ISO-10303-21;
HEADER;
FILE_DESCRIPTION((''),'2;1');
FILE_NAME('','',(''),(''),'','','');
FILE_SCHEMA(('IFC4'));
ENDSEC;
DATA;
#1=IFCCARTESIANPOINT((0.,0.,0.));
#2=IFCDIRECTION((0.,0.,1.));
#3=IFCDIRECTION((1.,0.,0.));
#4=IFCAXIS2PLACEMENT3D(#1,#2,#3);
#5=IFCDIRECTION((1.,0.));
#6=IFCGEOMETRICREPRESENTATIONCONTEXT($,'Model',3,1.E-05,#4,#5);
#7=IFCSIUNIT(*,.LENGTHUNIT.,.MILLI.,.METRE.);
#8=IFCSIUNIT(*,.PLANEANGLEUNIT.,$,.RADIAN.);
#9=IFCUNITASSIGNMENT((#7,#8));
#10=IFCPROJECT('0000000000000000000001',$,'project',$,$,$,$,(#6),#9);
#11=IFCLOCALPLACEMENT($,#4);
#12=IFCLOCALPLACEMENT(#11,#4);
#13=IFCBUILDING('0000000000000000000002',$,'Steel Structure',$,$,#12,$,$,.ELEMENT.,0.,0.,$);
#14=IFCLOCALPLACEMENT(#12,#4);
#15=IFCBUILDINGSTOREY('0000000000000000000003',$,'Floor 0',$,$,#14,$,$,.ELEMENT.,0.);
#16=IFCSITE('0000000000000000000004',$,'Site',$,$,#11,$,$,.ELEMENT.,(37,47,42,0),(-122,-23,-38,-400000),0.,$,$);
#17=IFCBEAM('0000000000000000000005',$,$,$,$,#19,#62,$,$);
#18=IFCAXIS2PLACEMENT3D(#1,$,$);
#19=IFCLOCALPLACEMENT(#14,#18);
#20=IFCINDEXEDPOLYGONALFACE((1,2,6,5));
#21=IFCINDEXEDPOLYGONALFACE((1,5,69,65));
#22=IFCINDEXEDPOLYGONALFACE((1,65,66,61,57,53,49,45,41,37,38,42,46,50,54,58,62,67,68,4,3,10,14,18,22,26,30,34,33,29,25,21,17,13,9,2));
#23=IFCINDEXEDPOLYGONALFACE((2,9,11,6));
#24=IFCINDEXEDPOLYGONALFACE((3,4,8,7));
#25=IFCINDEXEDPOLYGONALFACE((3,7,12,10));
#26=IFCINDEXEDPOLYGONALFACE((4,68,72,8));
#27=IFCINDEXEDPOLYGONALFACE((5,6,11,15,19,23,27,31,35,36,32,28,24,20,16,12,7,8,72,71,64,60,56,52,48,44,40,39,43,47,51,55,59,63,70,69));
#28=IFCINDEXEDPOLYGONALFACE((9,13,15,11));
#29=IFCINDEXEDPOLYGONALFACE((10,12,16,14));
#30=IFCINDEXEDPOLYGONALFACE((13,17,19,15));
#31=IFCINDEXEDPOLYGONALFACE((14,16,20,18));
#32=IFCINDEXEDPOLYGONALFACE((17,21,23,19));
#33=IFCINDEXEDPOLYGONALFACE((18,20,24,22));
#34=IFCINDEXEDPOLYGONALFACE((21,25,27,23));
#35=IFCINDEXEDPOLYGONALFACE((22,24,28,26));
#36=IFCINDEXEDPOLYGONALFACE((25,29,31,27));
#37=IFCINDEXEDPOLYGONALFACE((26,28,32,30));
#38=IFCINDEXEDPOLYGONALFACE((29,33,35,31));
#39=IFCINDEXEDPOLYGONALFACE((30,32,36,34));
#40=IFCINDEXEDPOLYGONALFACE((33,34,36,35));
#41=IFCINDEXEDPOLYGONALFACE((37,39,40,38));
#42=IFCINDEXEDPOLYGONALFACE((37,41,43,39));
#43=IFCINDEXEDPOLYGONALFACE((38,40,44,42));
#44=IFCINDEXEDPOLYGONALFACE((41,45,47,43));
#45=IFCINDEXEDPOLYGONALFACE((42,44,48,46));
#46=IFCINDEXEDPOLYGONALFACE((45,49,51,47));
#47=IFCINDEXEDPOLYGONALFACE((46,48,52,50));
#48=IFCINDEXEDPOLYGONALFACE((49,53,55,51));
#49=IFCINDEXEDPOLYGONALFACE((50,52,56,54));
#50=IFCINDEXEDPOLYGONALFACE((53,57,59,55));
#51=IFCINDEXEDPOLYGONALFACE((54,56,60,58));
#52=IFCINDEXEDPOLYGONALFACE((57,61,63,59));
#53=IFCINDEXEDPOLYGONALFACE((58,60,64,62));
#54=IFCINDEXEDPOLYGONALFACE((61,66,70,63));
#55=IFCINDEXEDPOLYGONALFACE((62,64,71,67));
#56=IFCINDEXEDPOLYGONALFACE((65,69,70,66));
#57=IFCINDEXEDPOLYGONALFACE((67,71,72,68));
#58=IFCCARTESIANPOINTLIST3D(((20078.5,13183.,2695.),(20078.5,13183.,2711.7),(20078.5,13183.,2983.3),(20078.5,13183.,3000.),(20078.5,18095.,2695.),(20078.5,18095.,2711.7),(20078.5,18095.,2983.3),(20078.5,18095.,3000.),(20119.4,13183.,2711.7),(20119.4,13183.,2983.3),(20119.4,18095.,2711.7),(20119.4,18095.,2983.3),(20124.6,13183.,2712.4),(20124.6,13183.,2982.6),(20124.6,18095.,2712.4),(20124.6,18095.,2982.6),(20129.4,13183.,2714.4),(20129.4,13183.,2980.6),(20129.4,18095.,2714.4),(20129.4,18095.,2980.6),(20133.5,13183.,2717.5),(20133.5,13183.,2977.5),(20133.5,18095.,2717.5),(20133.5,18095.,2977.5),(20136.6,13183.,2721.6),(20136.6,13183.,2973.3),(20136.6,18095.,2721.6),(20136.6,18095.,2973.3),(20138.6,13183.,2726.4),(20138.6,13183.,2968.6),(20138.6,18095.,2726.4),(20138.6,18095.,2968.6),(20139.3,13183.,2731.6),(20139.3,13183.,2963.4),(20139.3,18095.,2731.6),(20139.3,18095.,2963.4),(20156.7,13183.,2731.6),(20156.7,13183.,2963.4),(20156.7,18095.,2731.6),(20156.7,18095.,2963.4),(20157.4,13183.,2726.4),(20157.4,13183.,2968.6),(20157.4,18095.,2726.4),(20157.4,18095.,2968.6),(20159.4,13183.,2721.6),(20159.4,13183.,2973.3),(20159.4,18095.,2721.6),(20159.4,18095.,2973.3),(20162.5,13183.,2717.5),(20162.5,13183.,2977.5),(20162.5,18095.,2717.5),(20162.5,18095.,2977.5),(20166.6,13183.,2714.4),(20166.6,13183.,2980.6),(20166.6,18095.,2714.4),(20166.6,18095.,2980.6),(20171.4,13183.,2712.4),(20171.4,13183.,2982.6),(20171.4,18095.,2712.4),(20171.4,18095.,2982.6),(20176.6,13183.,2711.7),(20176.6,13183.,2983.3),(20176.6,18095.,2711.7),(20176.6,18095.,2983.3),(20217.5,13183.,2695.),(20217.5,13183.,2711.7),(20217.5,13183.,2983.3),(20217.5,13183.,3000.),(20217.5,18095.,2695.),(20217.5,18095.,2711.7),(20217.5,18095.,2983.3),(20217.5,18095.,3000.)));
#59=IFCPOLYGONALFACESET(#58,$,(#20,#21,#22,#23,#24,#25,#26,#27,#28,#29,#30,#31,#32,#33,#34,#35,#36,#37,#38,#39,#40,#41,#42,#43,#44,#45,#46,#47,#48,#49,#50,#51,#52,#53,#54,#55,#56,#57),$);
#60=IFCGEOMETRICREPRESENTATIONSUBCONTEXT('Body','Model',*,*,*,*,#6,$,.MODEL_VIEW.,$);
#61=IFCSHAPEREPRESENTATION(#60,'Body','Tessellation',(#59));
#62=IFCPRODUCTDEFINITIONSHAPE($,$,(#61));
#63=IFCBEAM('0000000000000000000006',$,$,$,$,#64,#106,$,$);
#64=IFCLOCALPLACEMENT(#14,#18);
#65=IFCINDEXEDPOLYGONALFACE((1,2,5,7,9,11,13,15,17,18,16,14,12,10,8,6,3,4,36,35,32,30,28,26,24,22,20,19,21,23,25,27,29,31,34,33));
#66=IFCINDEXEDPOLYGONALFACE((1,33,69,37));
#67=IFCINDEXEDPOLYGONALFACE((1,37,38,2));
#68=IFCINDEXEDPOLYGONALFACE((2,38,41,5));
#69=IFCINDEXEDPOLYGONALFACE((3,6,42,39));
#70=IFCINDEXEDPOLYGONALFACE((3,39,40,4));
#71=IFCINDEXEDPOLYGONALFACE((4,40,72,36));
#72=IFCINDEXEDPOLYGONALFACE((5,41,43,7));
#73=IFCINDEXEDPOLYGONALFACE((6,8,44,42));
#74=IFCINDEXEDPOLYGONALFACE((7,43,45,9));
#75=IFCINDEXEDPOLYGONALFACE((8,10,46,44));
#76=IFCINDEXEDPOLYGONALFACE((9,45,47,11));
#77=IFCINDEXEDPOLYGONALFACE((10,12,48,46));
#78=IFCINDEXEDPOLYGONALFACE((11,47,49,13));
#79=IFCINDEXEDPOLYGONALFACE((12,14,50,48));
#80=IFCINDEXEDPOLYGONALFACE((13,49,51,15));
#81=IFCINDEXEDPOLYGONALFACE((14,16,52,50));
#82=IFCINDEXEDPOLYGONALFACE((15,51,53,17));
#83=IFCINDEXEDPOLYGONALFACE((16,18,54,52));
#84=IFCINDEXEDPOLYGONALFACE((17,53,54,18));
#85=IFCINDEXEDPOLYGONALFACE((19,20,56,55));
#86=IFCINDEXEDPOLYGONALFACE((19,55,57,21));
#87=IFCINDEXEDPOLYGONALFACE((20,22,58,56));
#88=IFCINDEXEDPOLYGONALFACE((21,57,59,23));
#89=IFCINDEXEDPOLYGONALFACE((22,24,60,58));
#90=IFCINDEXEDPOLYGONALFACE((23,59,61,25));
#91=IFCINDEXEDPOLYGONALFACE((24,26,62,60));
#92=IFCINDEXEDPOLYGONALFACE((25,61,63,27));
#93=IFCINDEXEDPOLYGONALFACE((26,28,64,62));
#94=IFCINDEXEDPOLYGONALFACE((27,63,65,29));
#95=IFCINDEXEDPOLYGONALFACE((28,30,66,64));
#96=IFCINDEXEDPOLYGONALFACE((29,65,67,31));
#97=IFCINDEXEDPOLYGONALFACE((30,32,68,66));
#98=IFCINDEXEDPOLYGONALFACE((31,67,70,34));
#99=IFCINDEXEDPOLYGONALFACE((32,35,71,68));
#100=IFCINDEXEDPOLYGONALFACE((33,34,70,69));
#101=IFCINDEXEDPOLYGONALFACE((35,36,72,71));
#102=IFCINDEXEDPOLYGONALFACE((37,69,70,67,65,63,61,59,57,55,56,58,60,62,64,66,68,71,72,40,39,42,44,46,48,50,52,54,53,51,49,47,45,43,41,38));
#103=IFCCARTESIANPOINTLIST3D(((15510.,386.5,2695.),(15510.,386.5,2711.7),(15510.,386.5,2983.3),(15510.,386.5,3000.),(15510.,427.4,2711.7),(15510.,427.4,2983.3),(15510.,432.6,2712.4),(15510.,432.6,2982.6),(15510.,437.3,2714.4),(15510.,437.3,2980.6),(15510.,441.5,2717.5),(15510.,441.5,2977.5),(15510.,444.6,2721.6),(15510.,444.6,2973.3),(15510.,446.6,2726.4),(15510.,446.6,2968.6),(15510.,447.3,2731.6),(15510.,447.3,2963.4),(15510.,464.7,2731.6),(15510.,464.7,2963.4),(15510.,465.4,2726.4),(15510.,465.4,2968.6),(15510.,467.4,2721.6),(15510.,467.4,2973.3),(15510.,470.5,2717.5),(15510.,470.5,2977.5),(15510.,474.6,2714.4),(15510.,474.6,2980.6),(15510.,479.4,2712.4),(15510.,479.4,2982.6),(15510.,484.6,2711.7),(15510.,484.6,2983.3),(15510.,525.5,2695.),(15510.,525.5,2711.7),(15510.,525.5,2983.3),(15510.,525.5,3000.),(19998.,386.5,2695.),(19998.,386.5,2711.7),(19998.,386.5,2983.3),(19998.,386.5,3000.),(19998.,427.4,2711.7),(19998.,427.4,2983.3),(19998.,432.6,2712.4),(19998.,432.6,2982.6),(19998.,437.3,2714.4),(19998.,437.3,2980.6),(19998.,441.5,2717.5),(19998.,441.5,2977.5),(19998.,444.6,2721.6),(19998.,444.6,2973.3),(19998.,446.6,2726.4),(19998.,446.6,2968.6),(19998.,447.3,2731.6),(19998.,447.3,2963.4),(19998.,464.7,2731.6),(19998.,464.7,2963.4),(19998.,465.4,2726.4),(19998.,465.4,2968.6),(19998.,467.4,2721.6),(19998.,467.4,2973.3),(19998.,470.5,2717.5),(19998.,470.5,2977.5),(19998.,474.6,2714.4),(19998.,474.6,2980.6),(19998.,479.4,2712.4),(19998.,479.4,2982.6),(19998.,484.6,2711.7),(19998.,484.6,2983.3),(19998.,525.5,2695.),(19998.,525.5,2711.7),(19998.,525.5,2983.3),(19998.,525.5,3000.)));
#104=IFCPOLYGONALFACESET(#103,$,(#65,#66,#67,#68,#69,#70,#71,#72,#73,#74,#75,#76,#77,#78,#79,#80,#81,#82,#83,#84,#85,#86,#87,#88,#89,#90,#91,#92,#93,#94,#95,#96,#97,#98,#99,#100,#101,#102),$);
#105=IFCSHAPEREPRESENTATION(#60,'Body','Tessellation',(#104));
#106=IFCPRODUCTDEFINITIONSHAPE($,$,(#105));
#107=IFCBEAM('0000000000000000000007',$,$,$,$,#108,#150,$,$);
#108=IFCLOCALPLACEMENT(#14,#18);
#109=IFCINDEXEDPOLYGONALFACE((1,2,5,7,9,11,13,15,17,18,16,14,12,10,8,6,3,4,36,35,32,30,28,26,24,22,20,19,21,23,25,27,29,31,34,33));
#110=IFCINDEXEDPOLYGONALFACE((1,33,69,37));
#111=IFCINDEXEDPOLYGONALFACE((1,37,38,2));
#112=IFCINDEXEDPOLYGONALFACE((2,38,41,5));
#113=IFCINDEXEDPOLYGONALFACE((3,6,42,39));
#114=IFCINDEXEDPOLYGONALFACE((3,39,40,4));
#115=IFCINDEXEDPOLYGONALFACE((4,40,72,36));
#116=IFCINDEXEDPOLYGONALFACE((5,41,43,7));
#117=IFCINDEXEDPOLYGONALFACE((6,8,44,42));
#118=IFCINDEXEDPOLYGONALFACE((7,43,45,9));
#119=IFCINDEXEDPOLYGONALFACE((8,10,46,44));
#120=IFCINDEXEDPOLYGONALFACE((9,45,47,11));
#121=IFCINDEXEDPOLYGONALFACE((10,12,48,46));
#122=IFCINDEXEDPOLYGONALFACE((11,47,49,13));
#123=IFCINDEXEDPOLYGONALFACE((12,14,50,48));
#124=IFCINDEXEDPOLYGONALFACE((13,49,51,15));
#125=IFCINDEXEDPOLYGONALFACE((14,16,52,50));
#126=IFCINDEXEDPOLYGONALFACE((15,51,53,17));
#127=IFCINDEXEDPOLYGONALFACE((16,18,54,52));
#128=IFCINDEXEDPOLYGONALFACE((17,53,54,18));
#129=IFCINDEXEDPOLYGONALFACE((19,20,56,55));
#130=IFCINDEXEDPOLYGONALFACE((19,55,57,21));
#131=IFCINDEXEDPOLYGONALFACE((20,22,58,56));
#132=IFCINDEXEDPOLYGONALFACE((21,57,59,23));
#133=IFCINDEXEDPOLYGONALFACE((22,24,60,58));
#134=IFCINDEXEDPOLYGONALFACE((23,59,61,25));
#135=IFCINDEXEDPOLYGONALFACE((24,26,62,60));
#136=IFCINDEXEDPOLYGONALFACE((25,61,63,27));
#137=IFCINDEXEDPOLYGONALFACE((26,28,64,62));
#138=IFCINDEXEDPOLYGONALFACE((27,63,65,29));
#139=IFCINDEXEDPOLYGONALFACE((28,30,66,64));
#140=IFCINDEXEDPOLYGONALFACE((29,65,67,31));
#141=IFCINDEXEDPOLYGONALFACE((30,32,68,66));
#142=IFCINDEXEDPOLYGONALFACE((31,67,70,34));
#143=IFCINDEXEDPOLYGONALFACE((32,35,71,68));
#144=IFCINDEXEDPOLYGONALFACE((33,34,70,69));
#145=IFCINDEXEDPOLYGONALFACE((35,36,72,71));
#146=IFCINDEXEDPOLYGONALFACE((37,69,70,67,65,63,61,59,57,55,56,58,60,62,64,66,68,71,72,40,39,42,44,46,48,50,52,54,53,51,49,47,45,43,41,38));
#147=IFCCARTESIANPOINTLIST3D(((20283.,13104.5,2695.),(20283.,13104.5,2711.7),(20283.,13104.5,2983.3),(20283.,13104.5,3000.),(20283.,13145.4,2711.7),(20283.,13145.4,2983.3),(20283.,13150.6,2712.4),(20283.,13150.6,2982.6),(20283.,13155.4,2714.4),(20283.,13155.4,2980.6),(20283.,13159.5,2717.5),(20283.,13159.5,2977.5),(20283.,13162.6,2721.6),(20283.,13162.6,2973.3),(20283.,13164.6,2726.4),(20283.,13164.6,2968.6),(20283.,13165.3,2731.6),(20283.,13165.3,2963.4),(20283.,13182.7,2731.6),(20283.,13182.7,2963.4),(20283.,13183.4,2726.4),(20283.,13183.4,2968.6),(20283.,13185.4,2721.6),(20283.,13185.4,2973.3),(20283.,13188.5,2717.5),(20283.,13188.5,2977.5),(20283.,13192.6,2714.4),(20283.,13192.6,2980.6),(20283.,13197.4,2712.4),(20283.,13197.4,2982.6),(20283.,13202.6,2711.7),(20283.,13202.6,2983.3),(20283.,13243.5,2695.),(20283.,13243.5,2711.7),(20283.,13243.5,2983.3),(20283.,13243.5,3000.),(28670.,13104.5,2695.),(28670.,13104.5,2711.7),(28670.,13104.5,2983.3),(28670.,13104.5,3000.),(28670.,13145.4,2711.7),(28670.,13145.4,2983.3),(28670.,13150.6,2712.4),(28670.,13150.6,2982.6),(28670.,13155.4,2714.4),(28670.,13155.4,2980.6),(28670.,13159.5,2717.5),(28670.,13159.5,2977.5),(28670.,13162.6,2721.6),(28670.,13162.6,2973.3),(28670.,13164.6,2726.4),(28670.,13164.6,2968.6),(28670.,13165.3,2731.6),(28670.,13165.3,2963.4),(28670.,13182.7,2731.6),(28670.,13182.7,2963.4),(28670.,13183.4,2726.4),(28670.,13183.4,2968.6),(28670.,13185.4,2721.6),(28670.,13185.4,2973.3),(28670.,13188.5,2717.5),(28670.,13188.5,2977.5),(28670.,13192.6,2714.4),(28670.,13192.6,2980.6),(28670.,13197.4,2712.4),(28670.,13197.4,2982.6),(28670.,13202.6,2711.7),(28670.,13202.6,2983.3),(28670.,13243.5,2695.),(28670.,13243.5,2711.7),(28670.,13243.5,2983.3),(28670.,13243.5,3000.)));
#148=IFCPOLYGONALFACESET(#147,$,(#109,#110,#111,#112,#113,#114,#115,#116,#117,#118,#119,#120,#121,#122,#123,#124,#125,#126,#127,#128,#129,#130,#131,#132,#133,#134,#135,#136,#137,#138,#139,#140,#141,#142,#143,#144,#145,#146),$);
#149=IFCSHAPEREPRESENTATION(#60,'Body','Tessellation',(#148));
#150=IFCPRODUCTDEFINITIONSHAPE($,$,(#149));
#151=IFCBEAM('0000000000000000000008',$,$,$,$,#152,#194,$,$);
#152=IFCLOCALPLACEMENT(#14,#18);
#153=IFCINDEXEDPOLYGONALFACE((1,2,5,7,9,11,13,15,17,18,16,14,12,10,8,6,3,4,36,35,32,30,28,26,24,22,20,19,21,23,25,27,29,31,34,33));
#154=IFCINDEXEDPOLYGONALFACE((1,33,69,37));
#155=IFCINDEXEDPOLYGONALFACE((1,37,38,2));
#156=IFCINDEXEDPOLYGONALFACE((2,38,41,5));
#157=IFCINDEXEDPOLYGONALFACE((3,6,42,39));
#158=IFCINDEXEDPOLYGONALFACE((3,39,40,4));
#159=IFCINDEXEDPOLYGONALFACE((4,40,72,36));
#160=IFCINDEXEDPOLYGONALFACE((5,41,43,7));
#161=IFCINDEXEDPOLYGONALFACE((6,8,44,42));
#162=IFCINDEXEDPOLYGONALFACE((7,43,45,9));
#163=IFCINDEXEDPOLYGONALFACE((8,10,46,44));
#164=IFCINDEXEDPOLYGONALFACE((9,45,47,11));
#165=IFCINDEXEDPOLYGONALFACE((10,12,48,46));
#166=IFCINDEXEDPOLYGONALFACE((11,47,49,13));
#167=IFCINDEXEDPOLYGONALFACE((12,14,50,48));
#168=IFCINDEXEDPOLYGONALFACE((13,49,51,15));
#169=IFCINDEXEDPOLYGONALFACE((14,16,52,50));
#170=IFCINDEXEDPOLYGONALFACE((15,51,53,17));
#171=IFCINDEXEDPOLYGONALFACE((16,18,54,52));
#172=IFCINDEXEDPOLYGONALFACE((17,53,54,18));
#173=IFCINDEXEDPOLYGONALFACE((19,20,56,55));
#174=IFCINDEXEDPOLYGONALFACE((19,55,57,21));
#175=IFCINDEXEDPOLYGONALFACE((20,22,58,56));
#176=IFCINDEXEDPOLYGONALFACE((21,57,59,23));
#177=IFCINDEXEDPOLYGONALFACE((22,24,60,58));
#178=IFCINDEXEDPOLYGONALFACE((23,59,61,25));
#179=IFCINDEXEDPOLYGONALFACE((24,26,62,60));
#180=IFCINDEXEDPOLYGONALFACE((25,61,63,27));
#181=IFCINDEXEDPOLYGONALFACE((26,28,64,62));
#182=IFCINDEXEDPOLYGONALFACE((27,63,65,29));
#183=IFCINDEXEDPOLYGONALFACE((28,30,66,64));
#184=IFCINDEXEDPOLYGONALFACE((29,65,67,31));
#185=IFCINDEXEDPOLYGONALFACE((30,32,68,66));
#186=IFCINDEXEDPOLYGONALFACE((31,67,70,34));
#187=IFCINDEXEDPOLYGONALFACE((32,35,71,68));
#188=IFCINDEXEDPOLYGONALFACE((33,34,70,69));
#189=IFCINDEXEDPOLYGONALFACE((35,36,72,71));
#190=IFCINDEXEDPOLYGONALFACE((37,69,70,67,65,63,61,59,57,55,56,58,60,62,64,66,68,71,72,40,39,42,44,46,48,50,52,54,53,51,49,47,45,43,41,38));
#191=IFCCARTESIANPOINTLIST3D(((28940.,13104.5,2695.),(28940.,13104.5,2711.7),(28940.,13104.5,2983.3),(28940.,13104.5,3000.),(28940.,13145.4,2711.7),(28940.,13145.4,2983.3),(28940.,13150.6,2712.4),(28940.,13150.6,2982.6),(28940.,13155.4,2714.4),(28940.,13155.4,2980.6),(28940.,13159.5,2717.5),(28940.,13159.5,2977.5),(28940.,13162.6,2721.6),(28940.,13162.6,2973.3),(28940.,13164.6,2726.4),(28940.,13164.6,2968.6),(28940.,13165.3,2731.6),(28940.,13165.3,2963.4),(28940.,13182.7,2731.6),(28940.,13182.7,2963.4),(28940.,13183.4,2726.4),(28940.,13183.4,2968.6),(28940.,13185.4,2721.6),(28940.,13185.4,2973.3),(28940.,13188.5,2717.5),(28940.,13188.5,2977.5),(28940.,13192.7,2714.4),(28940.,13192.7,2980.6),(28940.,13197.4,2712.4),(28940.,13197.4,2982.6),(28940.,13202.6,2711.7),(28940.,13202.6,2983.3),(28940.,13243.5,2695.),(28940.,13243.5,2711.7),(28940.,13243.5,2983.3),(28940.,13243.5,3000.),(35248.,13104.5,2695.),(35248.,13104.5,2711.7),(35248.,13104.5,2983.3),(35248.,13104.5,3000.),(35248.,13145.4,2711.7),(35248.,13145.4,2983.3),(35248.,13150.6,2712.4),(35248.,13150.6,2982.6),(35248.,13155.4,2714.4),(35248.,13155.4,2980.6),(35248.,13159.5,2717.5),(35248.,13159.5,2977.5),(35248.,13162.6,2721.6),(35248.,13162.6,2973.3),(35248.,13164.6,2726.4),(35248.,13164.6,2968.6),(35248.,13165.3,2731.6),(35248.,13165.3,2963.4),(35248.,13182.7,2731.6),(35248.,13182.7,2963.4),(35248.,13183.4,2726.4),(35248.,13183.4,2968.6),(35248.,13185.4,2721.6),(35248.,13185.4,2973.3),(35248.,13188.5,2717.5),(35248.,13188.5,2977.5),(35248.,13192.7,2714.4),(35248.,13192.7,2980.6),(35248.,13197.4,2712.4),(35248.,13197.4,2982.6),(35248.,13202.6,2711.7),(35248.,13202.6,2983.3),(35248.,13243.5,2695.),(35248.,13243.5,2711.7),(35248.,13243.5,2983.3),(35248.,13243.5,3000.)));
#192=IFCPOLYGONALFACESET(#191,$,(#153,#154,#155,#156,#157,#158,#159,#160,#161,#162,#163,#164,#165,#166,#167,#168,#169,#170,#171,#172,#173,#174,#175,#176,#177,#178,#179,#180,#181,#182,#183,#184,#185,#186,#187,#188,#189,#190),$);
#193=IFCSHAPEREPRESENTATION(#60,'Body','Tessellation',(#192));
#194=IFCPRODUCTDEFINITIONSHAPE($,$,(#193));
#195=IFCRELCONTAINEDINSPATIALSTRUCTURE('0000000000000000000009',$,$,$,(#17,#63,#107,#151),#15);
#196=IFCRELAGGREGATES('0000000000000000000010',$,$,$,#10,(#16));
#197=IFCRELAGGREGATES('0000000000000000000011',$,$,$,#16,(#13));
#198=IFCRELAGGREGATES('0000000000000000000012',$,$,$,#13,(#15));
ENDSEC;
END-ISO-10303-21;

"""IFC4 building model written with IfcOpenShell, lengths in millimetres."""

from ifc_helpers import new_model, si_unit, direction, frame, origin_with_axes, origin_2d_with_axis, place, context, subcontext, project, spatial, i_section, extrude, element, save


model = new_model("IFC4")

# Units and contexts
model_context = context("Model", 3, precision=1e-05, world=origin_with_axes(), true_north=direction((1.0, 0.0)))
body_context = subcontext(model_context, "Body", "Model", "MODEL_VIEW")
ifc_project = project(units=[si_unit("LENGTHUNIT", "METRE", prefix="MILLI"), si_unit("PLANEANGLEUNIT", "RADIAN")], contexts=[model_context])

# Site, building, storey
site_placement = place(None, origin_with_axes())
site = spatial("IfcSite", under=ifc_project, at=site_placement, Name="Site", CompositionType="ELEMENT", RefLatitude=(37, 47, 42, 0), RefLongitude=(-122, -23, -38, -400000), RefElevation=0.0)
building_placement = place(site_placement, origin_with_axes())
building = spatial("IfcBuilding", under=site, at=building_placement, Name="Steel Structure", CompositionType="ELEMENT", ElevationOfRefHeight=0.0, ElevationOfTerrain=0.0)
storey_placement = place(building_placement, origin_with_axes())
storey = spatial("IfcBuildingStorey", under=building, at=storey_placement, Name="Floor 0", CompositionType="ELEMENT", Elevation=0.0)

# Beams
for number, where, z_axis, x_axis in (
    (1, (20148.0, 13183.0, 2695.0), (0.0, 1.0, 0.0), (-1.0, 0.0, 0.0)),
):
    element("IfcBeam", number, at=place(storey_placement, frame(where, z_axis=z_axis, x_axis=x_axis)), inside=storey, context=body_context, shape_type="SweptSolid", body=[
        extrude(i_section(OverallWidth=139.0, OverallDepth=305.0, WebThickness=17.4, FlangeThickness=16.7, FilletRadius=19.9, at=origin_2d_with_axis()), frame((0.0, 152.5, 0.0), z_axis=(0.0, 0.0, 1.0), x_axis=(1.0, 0.0, 0.0)), (0.0, 0.0, 1.0), 4912.0),
    ])
beam_1_placement = place(storey_placement, frame((15510.0, 456.0, 2695.0), z_axis=(1.0, 0.0, 0.0), x_axis=(0.0, 1.0, 0.0)))
element("IfcBeam", 2, at=beam_1_placement, inside=storey, context=body_context, shape_type="SweptSolid", body=[
    extrude(i_section(OverallWidth=139.0, OverallDepth=305.0, WebThickness=17.4, FlangeThickness=16.7, FilletRadius=19.9, at=origin_2d_with_axis()), frame((0.0, 152.5, 0.0), z_axis=(0.0, 0.0, 1.0), x_axis=(1.0, 0.0, 0.0)), (0.0, 0.0, 1.0), 4488.0),
])
beam_2_placement = place(storey_placement, frame((20283.0, 13174.0, 2695.0), z_axis=(1.0, 0.0, 0.0), x_axis=(0.0, 1.0, 0.0)))
element("IfcBeam", 3, at=beam_2_placement, inside=storey, context=body_context, shape_type="SweptSolid", body=[
    extrude(i_section(OverallWidth=139.0, OverallDepth=305.0, WebThickness=17.4, FlangeThickness=16.7, FilletRadius=19.9, at=origin_2d_with_axis()), frame((0.0, 152.5, 0.0), z_axis=(0.0, 0.0, 1.0), x_axis=(1.0, 0.0, 0.0)), (0.0, 0.0, 1.0), 8387.0),
])
beam_3_placement = place(storey_placement, frame((28940.0, 13174.0, 2695.0), z_axis=(1.0, 0.0, 0.0), x_axis=(0.0, 1.0, 0.0)))
element("IfcBeam", 4, at=beam_3_placement, inside=storey, context=body_context, shape_type="SweptSolid", body=[
    extrude(i_section(OverallWidth=139.0, OverallDepth=305.0, WebThickness=17.4, FlangeThickness=16.7, FilletRadius=19.9, at=origin_2d_with_axis()), frame((0.0, 152.5, 0.0), z_axis=(0.0, 0.0, 1.0), x_axis=(1.0, 0.0, 0.0)), (0.0, 0.0, 1.0), 6308.0),
])

save(model, "model.ifc")
